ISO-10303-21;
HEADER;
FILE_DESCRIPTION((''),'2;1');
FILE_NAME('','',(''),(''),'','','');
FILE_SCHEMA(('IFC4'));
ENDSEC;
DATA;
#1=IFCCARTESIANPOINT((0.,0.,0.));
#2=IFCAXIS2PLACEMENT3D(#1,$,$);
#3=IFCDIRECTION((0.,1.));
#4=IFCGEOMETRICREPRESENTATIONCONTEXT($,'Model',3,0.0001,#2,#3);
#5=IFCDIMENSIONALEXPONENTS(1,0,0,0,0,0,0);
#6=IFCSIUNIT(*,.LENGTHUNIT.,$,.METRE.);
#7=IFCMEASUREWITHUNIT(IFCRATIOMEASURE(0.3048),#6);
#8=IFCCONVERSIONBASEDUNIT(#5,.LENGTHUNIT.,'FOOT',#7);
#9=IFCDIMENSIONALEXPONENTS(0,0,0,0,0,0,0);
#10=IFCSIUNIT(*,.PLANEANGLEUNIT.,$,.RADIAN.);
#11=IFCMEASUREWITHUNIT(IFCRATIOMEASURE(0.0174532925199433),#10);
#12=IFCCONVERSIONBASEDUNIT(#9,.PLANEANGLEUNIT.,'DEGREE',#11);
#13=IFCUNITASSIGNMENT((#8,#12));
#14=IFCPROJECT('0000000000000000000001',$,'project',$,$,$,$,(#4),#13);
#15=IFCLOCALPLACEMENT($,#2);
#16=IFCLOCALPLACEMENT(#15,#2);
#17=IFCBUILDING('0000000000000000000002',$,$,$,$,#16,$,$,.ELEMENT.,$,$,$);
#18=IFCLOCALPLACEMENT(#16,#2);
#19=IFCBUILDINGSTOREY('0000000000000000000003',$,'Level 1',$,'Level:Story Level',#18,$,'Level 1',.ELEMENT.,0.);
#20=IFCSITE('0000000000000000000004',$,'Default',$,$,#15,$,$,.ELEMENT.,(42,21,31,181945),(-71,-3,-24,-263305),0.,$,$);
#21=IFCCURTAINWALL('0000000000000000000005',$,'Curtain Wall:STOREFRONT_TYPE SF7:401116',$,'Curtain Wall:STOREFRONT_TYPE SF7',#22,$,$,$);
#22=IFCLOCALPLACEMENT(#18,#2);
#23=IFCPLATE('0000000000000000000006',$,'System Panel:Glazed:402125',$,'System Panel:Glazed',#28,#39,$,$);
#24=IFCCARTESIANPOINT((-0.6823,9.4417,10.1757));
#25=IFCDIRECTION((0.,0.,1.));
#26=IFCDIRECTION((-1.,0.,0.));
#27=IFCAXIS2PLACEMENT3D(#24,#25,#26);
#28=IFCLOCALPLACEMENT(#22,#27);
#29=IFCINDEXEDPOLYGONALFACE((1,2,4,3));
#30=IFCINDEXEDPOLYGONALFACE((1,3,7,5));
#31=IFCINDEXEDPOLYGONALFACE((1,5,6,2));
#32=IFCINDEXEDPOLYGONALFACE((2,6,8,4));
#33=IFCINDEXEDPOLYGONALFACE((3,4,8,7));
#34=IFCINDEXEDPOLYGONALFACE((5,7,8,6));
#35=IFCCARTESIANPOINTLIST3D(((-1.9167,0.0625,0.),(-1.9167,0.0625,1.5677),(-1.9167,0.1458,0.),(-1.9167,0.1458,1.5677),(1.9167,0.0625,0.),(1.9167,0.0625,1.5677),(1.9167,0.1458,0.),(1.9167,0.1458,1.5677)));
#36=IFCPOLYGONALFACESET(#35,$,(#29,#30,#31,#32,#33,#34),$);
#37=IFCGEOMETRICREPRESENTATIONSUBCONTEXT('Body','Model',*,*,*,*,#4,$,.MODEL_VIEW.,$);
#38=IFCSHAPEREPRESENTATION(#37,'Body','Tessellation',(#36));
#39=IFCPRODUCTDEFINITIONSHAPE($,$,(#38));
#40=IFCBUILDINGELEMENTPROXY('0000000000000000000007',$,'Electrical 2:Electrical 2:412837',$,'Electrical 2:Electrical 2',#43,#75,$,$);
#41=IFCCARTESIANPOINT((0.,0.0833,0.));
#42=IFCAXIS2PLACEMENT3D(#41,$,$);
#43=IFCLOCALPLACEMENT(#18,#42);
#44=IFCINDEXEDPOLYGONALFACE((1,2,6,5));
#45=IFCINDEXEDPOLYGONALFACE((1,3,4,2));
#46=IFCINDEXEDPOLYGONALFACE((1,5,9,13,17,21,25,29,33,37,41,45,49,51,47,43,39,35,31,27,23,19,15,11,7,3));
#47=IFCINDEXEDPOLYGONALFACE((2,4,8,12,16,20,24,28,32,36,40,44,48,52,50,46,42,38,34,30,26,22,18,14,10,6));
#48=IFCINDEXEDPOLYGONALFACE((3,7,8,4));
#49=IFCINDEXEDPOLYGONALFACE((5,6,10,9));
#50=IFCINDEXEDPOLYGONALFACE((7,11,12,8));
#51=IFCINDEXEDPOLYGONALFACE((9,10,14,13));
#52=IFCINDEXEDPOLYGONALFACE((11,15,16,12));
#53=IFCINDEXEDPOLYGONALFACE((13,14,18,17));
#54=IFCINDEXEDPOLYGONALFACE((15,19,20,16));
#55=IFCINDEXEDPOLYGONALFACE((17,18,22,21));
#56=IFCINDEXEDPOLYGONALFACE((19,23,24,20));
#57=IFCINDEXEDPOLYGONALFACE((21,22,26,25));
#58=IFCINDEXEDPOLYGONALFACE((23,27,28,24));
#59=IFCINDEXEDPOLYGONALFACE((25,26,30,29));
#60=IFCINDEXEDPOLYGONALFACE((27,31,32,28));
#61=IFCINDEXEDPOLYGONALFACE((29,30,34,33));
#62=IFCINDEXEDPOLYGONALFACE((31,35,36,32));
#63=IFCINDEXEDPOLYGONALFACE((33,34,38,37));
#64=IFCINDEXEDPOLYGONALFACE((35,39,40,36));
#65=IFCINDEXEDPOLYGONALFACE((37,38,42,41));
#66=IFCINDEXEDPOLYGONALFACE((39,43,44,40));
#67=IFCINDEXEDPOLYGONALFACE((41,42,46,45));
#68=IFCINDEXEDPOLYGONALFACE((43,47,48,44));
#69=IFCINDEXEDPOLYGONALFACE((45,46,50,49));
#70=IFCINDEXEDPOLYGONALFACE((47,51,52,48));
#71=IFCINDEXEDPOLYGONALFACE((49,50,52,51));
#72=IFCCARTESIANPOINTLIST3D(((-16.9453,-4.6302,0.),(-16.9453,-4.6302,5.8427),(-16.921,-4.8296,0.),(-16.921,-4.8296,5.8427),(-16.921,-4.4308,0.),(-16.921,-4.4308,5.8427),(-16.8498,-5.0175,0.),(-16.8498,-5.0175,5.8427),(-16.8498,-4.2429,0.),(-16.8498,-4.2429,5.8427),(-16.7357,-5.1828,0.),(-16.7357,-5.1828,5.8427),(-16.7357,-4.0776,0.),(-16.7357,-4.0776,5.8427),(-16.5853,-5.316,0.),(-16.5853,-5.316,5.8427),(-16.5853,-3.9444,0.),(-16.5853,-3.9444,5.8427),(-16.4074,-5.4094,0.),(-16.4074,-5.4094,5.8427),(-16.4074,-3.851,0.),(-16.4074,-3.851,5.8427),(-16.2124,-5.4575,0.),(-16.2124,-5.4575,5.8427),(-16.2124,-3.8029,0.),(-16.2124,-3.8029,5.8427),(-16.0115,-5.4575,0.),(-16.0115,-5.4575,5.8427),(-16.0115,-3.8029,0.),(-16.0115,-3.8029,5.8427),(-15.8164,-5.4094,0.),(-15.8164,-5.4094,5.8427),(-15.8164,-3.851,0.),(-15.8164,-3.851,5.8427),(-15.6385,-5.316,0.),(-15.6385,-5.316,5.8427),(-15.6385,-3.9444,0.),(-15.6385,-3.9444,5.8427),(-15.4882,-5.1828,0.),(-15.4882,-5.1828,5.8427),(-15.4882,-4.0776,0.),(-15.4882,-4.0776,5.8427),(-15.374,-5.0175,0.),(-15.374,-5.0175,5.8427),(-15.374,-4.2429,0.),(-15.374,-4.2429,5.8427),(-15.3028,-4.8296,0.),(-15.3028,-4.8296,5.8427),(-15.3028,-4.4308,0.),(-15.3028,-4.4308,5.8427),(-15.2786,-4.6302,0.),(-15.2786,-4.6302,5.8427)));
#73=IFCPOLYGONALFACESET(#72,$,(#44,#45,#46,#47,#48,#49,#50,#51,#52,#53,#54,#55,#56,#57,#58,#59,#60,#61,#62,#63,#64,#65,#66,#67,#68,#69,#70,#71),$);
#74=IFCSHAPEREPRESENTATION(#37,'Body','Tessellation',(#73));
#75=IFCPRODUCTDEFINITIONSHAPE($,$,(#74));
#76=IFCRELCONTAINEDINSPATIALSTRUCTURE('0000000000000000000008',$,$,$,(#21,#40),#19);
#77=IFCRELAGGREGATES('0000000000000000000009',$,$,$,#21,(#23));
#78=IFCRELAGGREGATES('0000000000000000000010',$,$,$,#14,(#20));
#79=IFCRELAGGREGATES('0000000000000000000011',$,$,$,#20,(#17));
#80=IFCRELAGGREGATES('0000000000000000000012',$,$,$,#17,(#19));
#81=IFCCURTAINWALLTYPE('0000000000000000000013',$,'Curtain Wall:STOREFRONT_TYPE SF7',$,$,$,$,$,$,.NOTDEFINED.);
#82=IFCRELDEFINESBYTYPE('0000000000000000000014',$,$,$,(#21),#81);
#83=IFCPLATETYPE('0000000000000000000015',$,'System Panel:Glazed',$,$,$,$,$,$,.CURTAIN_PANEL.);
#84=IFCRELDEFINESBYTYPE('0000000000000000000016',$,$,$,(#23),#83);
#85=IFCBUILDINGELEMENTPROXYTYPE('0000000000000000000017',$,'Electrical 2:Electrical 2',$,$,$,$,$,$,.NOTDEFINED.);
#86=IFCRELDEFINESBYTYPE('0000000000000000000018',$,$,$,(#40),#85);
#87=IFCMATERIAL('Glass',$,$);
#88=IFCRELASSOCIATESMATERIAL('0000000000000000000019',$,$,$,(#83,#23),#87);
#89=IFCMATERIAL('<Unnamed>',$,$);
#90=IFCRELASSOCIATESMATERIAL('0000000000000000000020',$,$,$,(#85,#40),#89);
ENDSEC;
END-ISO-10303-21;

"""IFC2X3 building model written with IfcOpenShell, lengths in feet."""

from ifc_helpers import new_model, entity, si_unit, converted_unit, direction, frame, frame_2d, origin, place, context, subcontext, project, spatial, rectangle, circle, extrude, source, transform, mapped, material, type_object, type_shapes, element, aggregate, save


model = new_model("IFC2X3")

# Units and contexts
model_context = context("Model", 3, precision=0.0001, world=origin(), true_north=direction((0.0, 1.0)))
body_context = subcontext(model_context, "Body", "Model", "MODEL_VIEW")
ifc_project = project(units=[converted_unit("LENGTHUNIT", "FOOT", entity("IfcRatioMeasure", 0.3048), si_unit("LENGTHUNIT", "METRE"), dimensions=[1, 0, 0, 0, 0, 0, 0]), converted_unit("PLANEANGLEUNIT", "DEGREE", entity("IfcRatioMeasure", 0.0174532925199433), si_unit("PLANEANGLEUNIT", "RADIAN"), dimensions=[0, 0, 0, 0, 0, 0, 0])], contexts=[model_context])

# Site, building, storey
site_placement = place(None, origin())
site = spatial("IfcSite", under=ifc_project, at=site_placement, Name="Default", CompositionType="ELEMENT", RefLatitude=(42, 21, 31, 181945), RefLongitude=(-71, -3, -24, -263305), RefElevation=0.0)
building_placement = place(site_placement, origin())
building = spatial("IfcBuilding", under=site, at=building_placement, CompositionType="ELEMENT")
storey_placement = place(building_placement, origin())
storey = spatial("IfcBuildingStorey", under=building, at=storey_placement, Name="Level 1", ObjectType="Level:Story Level", LongName="Level 1", CompositionType="ELEMENT", Elevation=0.0)

# Curtain wall, plate
curtain_wall_type = type_object("IfcCurtainWallType", Name="Curtain Wall:STOREFRONT_TYPE SF7", PredefinedType="NOTDEFINED")
curtain_wall_placement = place(storey_placement, origin())
curtain_wall = element("IfcCurtainWall", 1, at=curtain_wall_placement, inside=storey, type_object=curtain_wall_type, Name="Curtain Wall:STOREFRONT_TYPE SF7:401116", ObjectType="Curtain Wall:STOREFRONT_TYPE SF7")
ifc_material_1 = material(Name="Glass")
plate_type = type_object("IfcPlateType", Name="System Panel:Glazed", PredefinedType="CURTAIN_PANEL", material=ifc_material_1)
shared_shape_1 = source(origin(), body_context, "Body", "SweptSolid", [
    extrude(rectangle(XDim=0.0833, YDim=3.8333, at=frame_2d((0.0, 0.0), x_axis=(1.0, 0.0))), frame((0.0, 0.1042, 0.0), z_axis=(0.0, 0.0, 1.0), x_axis=(0.0, 1.0, 0.0)), (0.0, 0.0, 1.0), 1.5677),
])
type_shapes(plate_type, [shared_shape_1])
plate_placement = place(curtain_wall_placement, frame((-0.6823, 9.4417, 10.1757), z_axis=(0.0, 0.0, 1.0), x_axis=(-1.0, 0.0, 0.0)))
plate = element("IfcPlate", 2, at=plate_placement, type_object=plate_type, material=ifc_material_1, Name="System Panel:Glazed:402125", ObjectType="System Panel:Glazed", context=body_context, shape_type="MappedRepresentation", body=[
    mapped(shared_shape_1, transform((0.0, 0.0, 0.0), scale=1.0)),
])
aggregate(curtain_wall, [plate])

# Building element proxy
ifc_material_2 = material(Name="<Unnamed>")
building_element_proxy_type = type_object("IfcBuildingElementProxyType", Name="Electrical 2:Electrical 2", PredefinedType="NOTDEFINED", material=ifc_material_2)
shared_shape_2 = source(origin(), body_context, "Body", "SweptSolid", [
    extrude(circle(Radius=0.8333, at=frame_2d((0.0, 0.0), x_axis=(1.0, 0.0))), frame((-16.1119, -4.6302, 0.0)), (0.0, 0.0, 1.0), 5.8427),
])
type_shapes(building_element_proxy_type, [shared_shape_2])
proxy_placement = place(storey_placement, frame((0.0, 0.0833, 0.0)))
element("IfcBuildingElementProxy", 3, at=proxy_placement, inside=storey, type_object=building_element_proxy_type, material=ifc_material_2, Name="Electrical 2:Electrical 2:412837", ObjectType="Electrical 2:Electrical 2", context=body_context, shape_type="MappedRepresentation", body=[
    mapped(shared_shape_2, transform((0.0, 0.0, 0.0), scale=1.0)),
])

save(model, "model.ifc")
